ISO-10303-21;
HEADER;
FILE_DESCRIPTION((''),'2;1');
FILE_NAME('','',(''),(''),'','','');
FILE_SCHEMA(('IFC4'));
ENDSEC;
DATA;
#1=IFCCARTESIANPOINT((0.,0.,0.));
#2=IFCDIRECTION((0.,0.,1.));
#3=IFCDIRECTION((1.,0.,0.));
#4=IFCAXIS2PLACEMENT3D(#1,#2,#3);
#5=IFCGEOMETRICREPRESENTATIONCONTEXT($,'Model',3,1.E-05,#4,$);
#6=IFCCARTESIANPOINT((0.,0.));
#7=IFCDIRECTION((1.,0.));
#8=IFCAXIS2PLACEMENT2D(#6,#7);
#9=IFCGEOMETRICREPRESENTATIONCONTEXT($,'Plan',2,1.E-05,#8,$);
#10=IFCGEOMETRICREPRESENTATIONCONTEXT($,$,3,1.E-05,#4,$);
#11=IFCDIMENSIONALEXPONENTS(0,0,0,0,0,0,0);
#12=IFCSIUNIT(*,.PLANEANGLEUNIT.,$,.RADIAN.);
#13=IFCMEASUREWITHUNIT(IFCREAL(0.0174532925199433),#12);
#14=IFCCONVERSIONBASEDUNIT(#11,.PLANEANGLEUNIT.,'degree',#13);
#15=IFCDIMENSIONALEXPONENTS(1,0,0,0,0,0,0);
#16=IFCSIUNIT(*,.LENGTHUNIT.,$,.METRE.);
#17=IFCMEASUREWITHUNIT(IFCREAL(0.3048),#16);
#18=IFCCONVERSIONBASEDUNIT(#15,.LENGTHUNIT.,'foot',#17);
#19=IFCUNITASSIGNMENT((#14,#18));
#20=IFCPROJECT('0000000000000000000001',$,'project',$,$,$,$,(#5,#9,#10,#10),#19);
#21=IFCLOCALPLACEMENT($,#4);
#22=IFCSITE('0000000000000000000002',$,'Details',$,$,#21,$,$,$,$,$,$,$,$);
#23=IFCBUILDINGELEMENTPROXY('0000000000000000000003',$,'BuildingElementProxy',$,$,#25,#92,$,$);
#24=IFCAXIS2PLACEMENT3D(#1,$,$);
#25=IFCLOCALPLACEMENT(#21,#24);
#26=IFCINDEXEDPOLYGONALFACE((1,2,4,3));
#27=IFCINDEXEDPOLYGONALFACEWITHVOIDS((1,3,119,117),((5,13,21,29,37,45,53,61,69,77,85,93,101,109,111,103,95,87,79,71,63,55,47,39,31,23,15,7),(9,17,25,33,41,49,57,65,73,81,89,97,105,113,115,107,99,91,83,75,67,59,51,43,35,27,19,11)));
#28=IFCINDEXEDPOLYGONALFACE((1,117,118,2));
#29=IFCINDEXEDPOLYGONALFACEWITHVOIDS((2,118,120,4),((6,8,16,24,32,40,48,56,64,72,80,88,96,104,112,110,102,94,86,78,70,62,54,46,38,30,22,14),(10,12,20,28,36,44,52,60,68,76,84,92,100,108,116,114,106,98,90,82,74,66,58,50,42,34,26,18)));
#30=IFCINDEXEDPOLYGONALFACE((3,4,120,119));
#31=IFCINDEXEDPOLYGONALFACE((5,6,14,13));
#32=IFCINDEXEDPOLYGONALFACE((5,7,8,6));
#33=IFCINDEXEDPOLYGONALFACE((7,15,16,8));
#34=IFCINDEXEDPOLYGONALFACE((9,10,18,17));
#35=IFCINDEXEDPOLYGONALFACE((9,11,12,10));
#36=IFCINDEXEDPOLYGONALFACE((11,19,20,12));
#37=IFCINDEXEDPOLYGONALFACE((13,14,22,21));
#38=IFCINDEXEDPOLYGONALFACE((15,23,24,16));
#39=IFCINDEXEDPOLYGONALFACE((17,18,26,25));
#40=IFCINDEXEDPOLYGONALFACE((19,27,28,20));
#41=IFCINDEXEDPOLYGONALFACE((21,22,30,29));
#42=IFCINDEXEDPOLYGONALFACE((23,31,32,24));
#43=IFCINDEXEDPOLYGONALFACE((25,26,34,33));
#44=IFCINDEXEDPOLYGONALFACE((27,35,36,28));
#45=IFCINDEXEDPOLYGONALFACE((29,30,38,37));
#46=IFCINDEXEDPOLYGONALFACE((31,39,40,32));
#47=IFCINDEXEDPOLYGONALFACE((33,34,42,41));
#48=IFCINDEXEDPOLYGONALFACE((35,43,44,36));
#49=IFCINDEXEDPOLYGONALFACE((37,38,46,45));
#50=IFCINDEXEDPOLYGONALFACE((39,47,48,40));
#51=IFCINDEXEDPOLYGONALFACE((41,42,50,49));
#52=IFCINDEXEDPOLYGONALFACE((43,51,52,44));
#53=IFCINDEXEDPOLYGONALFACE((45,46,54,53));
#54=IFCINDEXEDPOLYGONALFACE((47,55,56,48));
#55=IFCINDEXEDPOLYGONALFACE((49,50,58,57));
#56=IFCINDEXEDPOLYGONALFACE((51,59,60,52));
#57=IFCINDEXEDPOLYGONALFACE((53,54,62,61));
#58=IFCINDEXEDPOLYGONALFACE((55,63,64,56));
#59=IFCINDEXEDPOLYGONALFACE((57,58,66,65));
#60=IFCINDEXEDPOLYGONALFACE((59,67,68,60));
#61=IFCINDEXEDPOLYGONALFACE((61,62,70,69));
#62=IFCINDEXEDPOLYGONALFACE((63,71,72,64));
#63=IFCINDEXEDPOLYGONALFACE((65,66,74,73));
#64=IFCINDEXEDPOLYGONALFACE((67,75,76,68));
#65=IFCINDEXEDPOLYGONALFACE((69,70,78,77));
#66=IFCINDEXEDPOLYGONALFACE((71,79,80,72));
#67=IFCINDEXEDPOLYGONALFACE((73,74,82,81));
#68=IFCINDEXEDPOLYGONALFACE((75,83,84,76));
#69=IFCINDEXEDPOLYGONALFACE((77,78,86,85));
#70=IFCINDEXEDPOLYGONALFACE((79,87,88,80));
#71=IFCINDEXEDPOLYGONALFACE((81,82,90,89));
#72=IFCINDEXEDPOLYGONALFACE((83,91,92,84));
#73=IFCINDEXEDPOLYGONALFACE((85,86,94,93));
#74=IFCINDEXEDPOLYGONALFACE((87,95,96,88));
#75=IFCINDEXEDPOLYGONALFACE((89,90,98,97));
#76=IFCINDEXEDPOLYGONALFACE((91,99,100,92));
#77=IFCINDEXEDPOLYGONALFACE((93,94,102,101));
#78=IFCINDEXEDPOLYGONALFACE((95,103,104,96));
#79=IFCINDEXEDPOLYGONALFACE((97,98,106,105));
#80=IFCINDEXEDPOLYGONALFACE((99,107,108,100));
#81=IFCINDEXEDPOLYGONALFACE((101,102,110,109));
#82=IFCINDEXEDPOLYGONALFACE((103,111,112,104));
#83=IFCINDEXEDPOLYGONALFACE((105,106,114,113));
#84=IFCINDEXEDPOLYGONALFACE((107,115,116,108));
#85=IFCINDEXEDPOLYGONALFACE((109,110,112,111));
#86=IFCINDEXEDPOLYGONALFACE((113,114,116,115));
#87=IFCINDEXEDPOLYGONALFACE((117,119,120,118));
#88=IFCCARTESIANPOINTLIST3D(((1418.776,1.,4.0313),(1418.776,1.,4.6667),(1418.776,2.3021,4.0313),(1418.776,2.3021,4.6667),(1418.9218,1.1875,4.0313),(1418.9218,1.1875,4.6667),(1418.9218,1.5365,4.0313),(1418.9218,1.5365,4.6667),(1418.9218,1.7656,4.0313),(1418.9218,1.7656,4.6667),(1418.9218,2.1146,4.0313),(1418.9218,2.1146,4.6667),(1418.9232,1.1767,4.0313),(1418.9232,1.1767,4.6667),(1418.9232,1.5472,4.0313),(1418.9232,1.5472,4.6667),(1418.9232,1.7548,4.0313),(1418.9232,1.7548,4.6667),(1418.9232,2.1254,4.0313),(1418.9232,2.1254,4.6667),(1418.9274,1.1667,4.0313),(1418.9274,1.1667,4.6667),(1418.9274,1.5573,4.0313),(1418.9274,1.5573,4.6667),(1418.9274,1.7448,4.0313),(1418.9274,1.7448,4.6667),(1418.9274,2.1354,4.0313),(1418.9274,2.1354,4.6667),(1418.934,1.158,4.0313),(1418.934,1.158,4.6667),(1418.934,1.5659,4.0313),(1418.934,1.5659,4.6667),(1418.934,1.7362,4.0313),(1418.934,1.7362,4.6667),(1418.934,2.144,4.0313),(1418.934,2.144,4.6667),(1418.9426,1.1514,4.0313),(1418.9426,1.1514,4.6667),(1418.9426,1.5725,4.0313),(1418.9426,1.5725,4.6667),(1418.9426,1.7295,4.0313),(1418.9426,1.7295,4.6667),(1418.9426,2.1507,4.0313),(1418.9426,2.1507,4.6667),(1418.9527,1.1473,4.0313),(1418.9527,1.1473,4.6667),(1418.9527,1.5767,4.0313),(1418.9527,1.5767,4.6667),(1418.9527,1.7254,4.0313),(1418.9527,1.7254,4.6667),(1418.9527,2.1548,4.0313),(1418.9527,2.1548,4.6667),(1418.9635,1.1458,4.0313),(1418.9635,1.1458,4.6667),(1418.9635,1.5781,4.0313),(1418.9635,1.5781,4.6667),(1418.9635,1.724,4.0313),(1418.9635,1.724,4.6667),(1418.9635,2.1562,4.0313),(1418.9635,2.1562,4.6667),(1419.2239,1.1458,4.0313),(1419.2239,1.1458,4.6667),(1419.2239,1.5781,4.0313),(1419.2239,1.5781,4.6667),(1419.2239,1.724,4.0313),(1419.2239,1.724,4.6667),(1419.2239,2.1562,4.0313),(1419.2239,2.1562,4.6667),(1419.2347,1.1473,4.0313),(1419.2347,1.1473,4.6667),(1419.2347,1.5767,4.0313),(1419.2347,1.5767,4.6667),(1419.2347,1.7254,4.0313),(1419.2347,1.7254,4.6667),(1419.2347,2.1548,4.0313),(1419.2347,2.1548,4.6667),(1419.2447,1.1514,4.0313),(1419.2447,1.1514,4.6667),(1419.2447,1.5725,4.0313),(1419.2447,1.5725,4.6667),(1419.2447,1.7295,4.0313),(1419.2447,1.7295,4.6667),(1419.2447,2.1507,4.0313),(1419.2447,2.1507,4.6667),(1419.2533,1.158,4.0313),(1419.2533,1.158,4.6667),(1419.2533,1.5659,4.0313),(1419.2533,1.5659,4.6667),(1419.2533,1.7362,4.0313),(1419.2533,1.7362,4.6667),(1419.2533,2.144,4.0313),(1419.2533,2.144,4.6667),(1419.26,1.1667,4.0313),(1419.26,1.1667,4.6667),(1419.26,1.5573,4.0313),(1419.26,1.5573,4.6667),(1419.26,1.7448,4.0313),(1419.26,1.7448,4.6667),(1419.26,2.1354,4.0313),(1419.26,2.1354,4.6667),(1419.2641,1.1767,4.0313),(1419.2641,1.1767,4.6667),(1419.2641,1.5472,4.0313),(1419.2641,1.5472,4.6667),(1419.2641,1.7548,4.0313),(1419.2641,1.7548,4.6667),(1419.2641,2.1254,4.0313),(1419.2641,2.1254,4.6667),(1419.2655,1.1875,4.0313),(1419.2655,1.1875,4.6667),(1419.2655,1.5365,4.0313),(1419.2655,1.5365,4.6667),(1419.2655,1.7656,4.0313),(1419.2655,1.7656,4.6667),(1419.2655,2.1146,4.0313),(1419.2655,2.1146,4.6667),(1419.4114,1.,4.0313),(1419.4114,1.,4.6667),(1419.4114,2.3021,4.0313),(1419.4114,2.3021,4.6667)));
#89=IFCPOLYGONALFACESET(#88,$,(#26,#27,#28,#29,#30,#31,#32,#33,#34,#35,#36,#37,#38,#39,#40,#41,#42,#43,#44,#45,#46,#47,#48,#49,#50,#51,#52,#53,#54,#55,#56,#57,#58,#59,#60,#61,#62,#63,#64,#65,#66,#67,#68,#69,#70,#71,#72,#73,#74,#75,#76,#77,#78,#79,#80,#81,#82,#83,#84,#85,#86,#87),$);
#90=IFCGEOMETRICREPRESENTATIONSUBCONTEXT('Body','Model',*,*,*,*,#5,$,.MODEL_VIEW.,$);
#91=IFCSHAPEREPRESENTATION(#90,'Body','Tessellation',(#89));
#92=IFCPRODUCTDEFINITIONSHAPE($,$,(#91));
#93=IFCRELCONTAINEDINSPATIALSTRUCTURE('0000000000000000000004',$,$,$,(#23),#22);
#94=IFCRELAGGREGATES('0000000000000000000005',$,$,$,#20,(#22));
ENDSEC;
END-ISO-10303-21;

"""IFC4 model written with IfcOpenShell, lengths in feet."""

from ifc_helpers import new_model, entity, si_unit, converted_unit, frame, origin_with_axes, origin_2d_with_axis, place, context, subcontext, project, spatial, line, indexed_curve, outline, extrude, element, save


model = new_model("IFC4")

# Units and contexts
model_context = context("Model", 3, precision=1e-05, world=origin_with_axes())
plan_context = context("Plan", 2, precision=1e-05, world=origin_2d_with_axis())
context_of_model = context(None, 3, precision=1e-05, world=origin_with_axes())
body_context = subcontext(model_context, "Body", "Model", "MODEL_VIEW")
ifc_project = project(units=[converted_unit("PLANEANGLEUNIT", "degree", entity("IfcReal", 0.0174532925199433), si_unit("PLANEANGLEUNIT", "RADIAN"), dimensions=[0, 0, 0, 0, 0, 0, 0]), converted_unit("LENGTHUNIT", "foot", entity("IfcReal", 0.3048), si_unit("LENGTHUNIT", "METRE"), dimensions=[1, 0, 0, 0, 0, 0, 0])], contexts=[model_context, plan_context, context_of_model, context_of_model])

# Site
site_placement = place(None, origin_with_axes())
site = spatial("IfcSite", under=ifc_project, at=site_placement, Name="Details")

# Building element proxy
proxy_1_placement = place(site_placement, frame((1419.0936, 2.3021, 4.0313), z_axis=(0.0, 0.0, 1.0), x_axis=(0.0, 1.0, 0.0)))
element("IfcBuildingElementProxy", 1, at=proxy_1_placement, inside=site, Name="BuildingElementProxy", context=body_context, shape_type="SweptSolid", body=[
    extrude(outline(indexed_curve([(-0.3177, -0.651), (0.3177, -0.651), (0.3177, 0.651), (-0.3177, 0.651), (0.1719, -0.1146), (0.1719, -0.4635), (0.1705, -0.4743), (0.1663, -0.4844), (0.1597, -0.493), (0.151, -0.4996), (0.141, -0.5038), (0.1302, -0.5052), (-0.1302, -0.5052), (-0.141, -0.5038), (-0.151, -0.4996), (-0.1597, -0.493), (-0.1663, -0.4844), (-0.1705, -0.4743), (-0.1719, -0.4635), (-0.1719, -0.1146), (-0.1705, -0.1038), (-0.1663, -0.0938), (-0.1597, -0.0851), (-0.151, -0.0785), (-0.141, -0.0743), (-0.1302, -0.0729), (0.1302, -0.0729), (0.141, -0.0743), (0.151, -0.0785), (0.1597, -0.0851), (0.1663, -0.0938), (0.1705, -0.1038), (0.151, 0.0785), (0.141, 0.0743), (0.1302, 0.0729), (-0.1302, 0.0729), (-0.141, 0.0743), (-0.151, 0.0785), (-0.1597, 0.0851), (-0.1663, 0.0937), (-0.1705, 0.1038), (-0.1719, 0.1146), (-0.1719, 0.4635), (-0.1705, 0.4743), (-0.1663, 0.4844), (-0.1597, 0.493), (-0.151, 0.4996), (-0.141, 0.5038), (-0.1302, 0.5052), (0.1302, 0.5052), (0.141, 0.5038), (0.151, 0.4996), (0.1597, 0.493), (0.1663, 0.4844), (0.1705, 0.4743), (0.1719, 0.4635), (0.1719, 0.1146), (0.1705, 0.1038), (0.1663, 0.0937), (0.1597, 0.0851)], segments=[line(4, 3), line(3, 2), line(2, 1), line(1, 4)], self_intersect=False), holes=[indexed_curve([(-0.3177, -0.651), (0.3177, -0.651), (0.3177, 0.651), (-0.3177, 0.651), (0.1719, -0.1146), (0.1719, -0.4635), (0.1705, -0.4743), (0.1663, -0.4844), (0.1597, -0.493), (0.151, -0.4996), (0.141, -0.5038), (0.1302, -0.5052), (-0.1302, -0.5052), (-0.141, -0.5038), (-0.151, -0.4996), (-0.1597, -0.493), (-0.1663, -0.4844), (-0.1705, -0.4743), (-0.1719, -0.4635), (-0.1719, -0.1146), (-0.1705, -0.1038), (-0.1663, -0.0938), (-0.1597, -0.0851), (-0.151, -0.0785), (-0.141, -0.0743), (-0.1302, -0.0729), (0.1302, -0.0729), (0.141, -0.0743), (0.151, -0.0785), (0.1597, -0.0851), (0.1663, -0.0938), (0.1705, -0.1038), (0.151, 0.0785), (0.141, 0.0743), (0.1302, 0.0729), (-0.1302, 0.0729), (-0.141, 0.0743), (-0.151, 0.0785), (-0.1597, 0.0851), (-0.1663, 0.0937), (-0.1705, 0.1038), (-0.1719, 0.1146), (-0.1719, 0.4635), (-0.1705, 0.4743), (-0.1663, 0.4844), (-0.1597, 0.493), (-0.151, 0.4996), (-0.141, 0.5038), (-0.1302, 0.5052), (0.1302, 0.5052), (0.141, 0.5038), (0.151, 0.4996), (0.1597, 0.493), (0.1663, 0.4844), (0.1705, 0.4743), (0.1719, 0.4635), (0.1719, 0.1146), (0.1705, 0.1038), (0.1663, 0.0937), (0.1597, 0.0851)], segments=[line(20, 19), line(19, 18), line(18, 17), line(17, 16), line(16, 15), line(15, 14), line(14, 13), line(13, 12), line(12, 11), line(11, 10), line(10, 9), line(9, 8), line(8, 7), line(7, 6), line(6, 5), line(5, 32), line(32, 31), line(31, 30), line(30, 29), line(29, 28), line(28, 27), line(27, 26), line(26, 25), line(25, 24), line(24, 23), line(23, 22), line(22, 21), line(21, 20)], self_intersect=False), indexed_curve([(-0.3177, -0.651), (0.3177, -0.651), (0.3177, 0.651), (-0.3177, 0.651), (0.1719, -0.1146), (0.1719, -0.4635), (0.1705, -0.4743), (0.1663, -0.4844), (0.1597, -0.493), (0.151, -0.4996), (0.141, -0.5038), (0.1302, -0.5052), (-0.1302, -0.5052), (-0.141, -0.5038), (-0.151, -0.4996), (-0.1597, -0.493), (-0.1663, -0.4844), (-0.1705, -0.4743), (-0.1719, -0.4635), (-0.1719, -0.1146), (-0.1705, -0.1038), (-0.1663, -0.0938), (-0.1597, -0.0851), (-0.151, -0.0785), (-0.141, -0.0743), (-0.1302, -0.0729), (0.1302, -0.0729), (0.141, -0.0743), (0.151, -0.0785), (0.1597, -0.0851), (0.1663, -0.0938), (0.1705, -0.1038), (0.151, 0.0785), (0.141, 0.0743), (0.1302, 0.0729), (-0.1302, 0.0729), (-0.141, 0.0743), (-0.151, 0.0785), (-0.1597, 0.0851), (-0.1663, 0.0937), (-0.1705, 0.1038), (-0.1719, 0.1146), (-0.1719, 0.4635), (-0.1705, 0.4743), (-0.1663, 0.4844), (-0.1597, 0.493), (-0.151, 0.4996), (-0.141, 0.5038), (-0.1302, 0.5052), (0.1302, 0.5052), (0.141, 0.5038), (0.151, 0.4996), (0.1597, 0.493), (0.1663, 0.4844), (0.1705, 0.4743), (0.1719, 0.4635), (0.1719, 0.1146), (0.1705, 0.1038), (0.1663, 0.0937), (0.1597, 0.0851)], segments=[line(44, 43), line(43, 42), line(42, 41), line(41, 40), line(40, 39), line(39, 38), line(38, 37), line(37, 36), line(36, 35), line(35, 34), line(34, 33), line(33, 60), line(60, 59), line(59, 58), line(58, 57), line(57, 56), line(56, 55), line(55, 54), line(54, 53), line(53, 52), line(52, 51), line(51, 50), line(50, 49), line(49, 48), line(48, 47), line(47, 46), line(46, 45), line(45, 44)], self_intersect=False)]), frame((-0.651, 0.0, 0.0), z_axis=(0.0, 0.0, 1.0), x_axis=(0.0, -1.0, 0.0)), (0.0, 0.0, 1.0), 0.6354),
])

save(model, "model.ifc")
